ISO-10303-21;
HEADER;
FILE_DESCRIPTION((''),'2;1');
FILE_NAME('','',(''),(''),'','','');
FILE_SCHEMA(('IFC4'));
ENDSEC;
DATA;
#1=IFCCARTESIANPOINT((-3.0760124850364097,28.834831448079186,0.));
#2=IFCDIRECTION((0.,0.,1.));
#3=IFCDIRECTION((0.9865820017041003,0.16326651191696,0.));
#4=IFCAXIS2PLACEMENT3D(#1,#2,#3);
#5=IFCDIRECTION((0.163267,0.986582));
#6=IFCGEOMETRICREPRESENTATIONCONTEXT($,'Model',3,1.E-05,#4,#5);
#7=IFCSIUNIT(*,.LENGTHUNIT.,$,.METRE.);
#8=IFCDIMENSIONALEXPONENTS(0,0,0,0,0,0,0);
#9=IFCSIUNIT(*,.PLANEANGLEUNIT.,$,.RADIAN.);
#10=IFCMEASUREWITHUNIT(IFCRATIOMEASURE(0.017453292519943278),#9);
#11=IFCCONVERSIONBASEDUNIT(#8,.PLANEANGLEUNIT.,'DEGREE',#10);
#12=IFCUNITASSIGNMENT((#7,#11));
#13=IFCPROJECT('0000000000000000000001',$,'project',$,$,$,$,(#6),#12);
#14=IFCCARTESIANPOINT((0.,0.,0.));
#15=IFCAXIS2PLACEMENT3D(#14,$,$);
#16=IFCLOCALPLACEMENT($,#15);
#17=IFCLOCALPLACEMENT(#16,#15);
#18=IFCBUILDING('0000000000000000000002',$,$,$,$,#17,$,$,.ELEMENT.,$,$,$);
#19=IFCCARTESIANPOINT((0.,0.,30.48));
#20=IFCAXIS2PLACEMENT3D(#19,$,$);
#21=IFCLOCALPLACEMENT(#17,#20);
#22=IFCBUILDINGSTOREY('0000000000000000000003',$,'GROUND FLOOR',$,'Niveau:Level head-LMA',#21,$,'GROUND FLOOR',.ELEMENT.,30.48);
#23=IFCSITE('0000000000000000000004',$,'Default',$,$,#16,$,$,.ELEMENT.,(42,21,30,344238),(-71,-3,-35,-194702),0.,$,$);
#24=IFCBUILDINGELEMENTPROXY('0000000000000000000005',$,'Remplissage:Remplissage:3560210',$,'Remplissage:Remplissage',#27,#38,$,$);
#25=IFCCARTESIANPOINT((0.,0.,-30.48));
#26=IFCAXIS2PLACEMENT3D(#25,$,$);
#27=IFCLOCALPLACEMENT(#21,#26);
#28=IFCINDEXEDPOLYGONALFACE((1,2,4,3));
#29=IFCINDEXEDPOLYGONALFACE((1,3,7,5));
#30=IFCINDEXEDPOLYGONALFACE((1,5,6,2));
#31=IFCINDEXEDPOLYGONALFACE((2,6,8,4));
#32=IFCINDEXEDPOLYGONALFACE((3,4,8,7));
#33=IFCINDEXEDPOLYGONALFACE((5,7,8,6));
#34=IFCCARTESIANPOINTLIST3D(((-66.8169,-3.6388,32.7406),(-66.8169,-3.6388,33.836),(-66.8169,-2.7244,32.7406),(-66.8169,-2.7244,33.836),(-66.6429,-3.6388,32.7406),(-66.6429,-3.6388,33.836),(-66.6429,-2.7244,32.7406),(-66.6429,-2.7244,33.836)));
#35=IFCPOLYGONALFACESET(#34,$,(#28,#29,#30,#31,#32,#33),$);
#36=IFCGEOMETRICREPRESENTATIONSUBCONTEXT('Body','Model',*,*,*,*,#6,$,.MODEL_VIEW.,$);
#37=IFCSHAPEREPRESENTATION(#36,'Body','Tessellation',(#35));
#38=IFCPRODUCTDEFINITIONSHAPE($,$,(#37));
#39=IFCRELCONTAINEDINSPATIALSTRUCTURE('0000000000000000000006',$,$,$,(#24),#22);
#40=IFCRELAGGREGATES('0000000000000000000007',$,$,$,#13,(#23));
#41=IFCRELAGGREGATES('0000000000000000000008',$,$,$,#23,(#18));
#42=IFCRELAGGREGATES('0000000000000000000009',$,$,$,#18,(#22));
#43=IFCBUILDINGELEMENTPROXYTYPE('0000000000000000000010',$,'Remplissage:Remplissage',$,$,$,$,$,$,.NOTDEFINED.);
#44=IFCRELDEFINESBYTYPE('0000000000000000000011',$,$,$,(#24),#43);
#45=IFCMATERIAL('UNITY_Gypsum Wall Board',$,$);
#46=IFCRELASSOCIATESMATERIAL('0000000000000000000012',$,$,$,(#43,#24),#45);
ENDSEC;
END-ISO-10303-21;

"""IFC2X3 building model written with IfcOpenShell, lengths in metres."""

from ifc_helpers import new_model, entity, si_unit, converted_unit, direction, frame, origin, origin_2d_with_axis, place, context, subcontext, project, spatial, rectangle, extrude, source, transform, mapped, material, type_object, type_shapes, element, save


model = new_model("IFC2X3")

# Units and contexts
model_context = context("Model", 3, precision=1e-05, world=frame((-3.0760124850364097, 28.834831448079186, 0.0), z_axis=(0.0, 0.0, 1.0), x_axis=(0.9865820017041003, 0.16326651191696, 0.0)), true_north=direction((0.163267, 0.986582)))
body_context = subcontext(model_context, "Body", "Model", "MODEL_VIEW")
ifc_project = project(units=[si_unit("LENGTHUNIT", "METRE"), converted_unit("PLANEANGLEUNIT", "DEGREE", entity("IfcRatioMeasure", 0.017453292519943278), si_unit("PLANEANGLEUNIT", "RADIAN"), dimensions=[0, 0, 0, 0, 0, 0, 0])], contexts=[model_context])

# Site, building, storey
site_placement = place(None, origin())
site = spatial("IfcSite", under=ifc_project, at=site_placement, Name="Default", CompositionType="ELEMENT", RefLatitude=(42, 21, 30, 344238), RefLongitude=(-71, -3, -35, -194702), RefElevation=0.0)
building_placement = place(site_placement, origin())
building = spatial("IfcBuilding", under=site, at=building_placement, CompositionType="ELEMENT")
storey_placement = place(building_placement, frame((0.0, 0.0, 30.48)))
storey = spatial("IfcBuildingStorey", under=building, at=storey_placement, Name="GROUND FLOOR", ObjectType="Niveau:Level head-LMA", LongName="GROUND FLOOR", CompositionType="ELEMENT", Elevation=30.48)

# Shared definitions
ifc_material_1 = material(Name="UNITY_Gypsum Wall Board")

# Building element proxy
building_element_proxy_type_1 = type_object("IfcBuildingElementProxyType", Name="Remplissage:Remplissage", PredefinedType="NOTDEFINED", material=ifc_material_1)
shared_shape_1 = source(origin(), body_context, "Body", "SweptSolid", [
    extrude(rectangle(XDim=0.174, YDim=0.9144, at=origin_2d_with_axis()), frame((-66.7299, -3.1816, 32.7406), z_axis=(0.0, 0.0, 1.0), x_axis=(-1.0, 0.0, 0.0)), (0.0, 0.0, 1.0), 1.0954),
])
type_shapes(building_element_proxy_type_1, [shared_shape_1])
proxy_1_placement = place(storey_placement, frame((0.0, 0.0, -30.48)))
element("IfcBuildingElementProxy", 1, at=proxy_1_placement, inside=storey, type_object=building_element_proxy_type_1, material=ifc_material_1, Name="Remplissage:Remplissage:3560210", ObjectType="Remplissage:Remplissage", context=body_context, shape_type="MappedRepresentation", body=[
    mapped(shared_shape_1, transform((0.0, 0.0, 0.0), scale=1.0)),
])

save(model, "model.ifc")
